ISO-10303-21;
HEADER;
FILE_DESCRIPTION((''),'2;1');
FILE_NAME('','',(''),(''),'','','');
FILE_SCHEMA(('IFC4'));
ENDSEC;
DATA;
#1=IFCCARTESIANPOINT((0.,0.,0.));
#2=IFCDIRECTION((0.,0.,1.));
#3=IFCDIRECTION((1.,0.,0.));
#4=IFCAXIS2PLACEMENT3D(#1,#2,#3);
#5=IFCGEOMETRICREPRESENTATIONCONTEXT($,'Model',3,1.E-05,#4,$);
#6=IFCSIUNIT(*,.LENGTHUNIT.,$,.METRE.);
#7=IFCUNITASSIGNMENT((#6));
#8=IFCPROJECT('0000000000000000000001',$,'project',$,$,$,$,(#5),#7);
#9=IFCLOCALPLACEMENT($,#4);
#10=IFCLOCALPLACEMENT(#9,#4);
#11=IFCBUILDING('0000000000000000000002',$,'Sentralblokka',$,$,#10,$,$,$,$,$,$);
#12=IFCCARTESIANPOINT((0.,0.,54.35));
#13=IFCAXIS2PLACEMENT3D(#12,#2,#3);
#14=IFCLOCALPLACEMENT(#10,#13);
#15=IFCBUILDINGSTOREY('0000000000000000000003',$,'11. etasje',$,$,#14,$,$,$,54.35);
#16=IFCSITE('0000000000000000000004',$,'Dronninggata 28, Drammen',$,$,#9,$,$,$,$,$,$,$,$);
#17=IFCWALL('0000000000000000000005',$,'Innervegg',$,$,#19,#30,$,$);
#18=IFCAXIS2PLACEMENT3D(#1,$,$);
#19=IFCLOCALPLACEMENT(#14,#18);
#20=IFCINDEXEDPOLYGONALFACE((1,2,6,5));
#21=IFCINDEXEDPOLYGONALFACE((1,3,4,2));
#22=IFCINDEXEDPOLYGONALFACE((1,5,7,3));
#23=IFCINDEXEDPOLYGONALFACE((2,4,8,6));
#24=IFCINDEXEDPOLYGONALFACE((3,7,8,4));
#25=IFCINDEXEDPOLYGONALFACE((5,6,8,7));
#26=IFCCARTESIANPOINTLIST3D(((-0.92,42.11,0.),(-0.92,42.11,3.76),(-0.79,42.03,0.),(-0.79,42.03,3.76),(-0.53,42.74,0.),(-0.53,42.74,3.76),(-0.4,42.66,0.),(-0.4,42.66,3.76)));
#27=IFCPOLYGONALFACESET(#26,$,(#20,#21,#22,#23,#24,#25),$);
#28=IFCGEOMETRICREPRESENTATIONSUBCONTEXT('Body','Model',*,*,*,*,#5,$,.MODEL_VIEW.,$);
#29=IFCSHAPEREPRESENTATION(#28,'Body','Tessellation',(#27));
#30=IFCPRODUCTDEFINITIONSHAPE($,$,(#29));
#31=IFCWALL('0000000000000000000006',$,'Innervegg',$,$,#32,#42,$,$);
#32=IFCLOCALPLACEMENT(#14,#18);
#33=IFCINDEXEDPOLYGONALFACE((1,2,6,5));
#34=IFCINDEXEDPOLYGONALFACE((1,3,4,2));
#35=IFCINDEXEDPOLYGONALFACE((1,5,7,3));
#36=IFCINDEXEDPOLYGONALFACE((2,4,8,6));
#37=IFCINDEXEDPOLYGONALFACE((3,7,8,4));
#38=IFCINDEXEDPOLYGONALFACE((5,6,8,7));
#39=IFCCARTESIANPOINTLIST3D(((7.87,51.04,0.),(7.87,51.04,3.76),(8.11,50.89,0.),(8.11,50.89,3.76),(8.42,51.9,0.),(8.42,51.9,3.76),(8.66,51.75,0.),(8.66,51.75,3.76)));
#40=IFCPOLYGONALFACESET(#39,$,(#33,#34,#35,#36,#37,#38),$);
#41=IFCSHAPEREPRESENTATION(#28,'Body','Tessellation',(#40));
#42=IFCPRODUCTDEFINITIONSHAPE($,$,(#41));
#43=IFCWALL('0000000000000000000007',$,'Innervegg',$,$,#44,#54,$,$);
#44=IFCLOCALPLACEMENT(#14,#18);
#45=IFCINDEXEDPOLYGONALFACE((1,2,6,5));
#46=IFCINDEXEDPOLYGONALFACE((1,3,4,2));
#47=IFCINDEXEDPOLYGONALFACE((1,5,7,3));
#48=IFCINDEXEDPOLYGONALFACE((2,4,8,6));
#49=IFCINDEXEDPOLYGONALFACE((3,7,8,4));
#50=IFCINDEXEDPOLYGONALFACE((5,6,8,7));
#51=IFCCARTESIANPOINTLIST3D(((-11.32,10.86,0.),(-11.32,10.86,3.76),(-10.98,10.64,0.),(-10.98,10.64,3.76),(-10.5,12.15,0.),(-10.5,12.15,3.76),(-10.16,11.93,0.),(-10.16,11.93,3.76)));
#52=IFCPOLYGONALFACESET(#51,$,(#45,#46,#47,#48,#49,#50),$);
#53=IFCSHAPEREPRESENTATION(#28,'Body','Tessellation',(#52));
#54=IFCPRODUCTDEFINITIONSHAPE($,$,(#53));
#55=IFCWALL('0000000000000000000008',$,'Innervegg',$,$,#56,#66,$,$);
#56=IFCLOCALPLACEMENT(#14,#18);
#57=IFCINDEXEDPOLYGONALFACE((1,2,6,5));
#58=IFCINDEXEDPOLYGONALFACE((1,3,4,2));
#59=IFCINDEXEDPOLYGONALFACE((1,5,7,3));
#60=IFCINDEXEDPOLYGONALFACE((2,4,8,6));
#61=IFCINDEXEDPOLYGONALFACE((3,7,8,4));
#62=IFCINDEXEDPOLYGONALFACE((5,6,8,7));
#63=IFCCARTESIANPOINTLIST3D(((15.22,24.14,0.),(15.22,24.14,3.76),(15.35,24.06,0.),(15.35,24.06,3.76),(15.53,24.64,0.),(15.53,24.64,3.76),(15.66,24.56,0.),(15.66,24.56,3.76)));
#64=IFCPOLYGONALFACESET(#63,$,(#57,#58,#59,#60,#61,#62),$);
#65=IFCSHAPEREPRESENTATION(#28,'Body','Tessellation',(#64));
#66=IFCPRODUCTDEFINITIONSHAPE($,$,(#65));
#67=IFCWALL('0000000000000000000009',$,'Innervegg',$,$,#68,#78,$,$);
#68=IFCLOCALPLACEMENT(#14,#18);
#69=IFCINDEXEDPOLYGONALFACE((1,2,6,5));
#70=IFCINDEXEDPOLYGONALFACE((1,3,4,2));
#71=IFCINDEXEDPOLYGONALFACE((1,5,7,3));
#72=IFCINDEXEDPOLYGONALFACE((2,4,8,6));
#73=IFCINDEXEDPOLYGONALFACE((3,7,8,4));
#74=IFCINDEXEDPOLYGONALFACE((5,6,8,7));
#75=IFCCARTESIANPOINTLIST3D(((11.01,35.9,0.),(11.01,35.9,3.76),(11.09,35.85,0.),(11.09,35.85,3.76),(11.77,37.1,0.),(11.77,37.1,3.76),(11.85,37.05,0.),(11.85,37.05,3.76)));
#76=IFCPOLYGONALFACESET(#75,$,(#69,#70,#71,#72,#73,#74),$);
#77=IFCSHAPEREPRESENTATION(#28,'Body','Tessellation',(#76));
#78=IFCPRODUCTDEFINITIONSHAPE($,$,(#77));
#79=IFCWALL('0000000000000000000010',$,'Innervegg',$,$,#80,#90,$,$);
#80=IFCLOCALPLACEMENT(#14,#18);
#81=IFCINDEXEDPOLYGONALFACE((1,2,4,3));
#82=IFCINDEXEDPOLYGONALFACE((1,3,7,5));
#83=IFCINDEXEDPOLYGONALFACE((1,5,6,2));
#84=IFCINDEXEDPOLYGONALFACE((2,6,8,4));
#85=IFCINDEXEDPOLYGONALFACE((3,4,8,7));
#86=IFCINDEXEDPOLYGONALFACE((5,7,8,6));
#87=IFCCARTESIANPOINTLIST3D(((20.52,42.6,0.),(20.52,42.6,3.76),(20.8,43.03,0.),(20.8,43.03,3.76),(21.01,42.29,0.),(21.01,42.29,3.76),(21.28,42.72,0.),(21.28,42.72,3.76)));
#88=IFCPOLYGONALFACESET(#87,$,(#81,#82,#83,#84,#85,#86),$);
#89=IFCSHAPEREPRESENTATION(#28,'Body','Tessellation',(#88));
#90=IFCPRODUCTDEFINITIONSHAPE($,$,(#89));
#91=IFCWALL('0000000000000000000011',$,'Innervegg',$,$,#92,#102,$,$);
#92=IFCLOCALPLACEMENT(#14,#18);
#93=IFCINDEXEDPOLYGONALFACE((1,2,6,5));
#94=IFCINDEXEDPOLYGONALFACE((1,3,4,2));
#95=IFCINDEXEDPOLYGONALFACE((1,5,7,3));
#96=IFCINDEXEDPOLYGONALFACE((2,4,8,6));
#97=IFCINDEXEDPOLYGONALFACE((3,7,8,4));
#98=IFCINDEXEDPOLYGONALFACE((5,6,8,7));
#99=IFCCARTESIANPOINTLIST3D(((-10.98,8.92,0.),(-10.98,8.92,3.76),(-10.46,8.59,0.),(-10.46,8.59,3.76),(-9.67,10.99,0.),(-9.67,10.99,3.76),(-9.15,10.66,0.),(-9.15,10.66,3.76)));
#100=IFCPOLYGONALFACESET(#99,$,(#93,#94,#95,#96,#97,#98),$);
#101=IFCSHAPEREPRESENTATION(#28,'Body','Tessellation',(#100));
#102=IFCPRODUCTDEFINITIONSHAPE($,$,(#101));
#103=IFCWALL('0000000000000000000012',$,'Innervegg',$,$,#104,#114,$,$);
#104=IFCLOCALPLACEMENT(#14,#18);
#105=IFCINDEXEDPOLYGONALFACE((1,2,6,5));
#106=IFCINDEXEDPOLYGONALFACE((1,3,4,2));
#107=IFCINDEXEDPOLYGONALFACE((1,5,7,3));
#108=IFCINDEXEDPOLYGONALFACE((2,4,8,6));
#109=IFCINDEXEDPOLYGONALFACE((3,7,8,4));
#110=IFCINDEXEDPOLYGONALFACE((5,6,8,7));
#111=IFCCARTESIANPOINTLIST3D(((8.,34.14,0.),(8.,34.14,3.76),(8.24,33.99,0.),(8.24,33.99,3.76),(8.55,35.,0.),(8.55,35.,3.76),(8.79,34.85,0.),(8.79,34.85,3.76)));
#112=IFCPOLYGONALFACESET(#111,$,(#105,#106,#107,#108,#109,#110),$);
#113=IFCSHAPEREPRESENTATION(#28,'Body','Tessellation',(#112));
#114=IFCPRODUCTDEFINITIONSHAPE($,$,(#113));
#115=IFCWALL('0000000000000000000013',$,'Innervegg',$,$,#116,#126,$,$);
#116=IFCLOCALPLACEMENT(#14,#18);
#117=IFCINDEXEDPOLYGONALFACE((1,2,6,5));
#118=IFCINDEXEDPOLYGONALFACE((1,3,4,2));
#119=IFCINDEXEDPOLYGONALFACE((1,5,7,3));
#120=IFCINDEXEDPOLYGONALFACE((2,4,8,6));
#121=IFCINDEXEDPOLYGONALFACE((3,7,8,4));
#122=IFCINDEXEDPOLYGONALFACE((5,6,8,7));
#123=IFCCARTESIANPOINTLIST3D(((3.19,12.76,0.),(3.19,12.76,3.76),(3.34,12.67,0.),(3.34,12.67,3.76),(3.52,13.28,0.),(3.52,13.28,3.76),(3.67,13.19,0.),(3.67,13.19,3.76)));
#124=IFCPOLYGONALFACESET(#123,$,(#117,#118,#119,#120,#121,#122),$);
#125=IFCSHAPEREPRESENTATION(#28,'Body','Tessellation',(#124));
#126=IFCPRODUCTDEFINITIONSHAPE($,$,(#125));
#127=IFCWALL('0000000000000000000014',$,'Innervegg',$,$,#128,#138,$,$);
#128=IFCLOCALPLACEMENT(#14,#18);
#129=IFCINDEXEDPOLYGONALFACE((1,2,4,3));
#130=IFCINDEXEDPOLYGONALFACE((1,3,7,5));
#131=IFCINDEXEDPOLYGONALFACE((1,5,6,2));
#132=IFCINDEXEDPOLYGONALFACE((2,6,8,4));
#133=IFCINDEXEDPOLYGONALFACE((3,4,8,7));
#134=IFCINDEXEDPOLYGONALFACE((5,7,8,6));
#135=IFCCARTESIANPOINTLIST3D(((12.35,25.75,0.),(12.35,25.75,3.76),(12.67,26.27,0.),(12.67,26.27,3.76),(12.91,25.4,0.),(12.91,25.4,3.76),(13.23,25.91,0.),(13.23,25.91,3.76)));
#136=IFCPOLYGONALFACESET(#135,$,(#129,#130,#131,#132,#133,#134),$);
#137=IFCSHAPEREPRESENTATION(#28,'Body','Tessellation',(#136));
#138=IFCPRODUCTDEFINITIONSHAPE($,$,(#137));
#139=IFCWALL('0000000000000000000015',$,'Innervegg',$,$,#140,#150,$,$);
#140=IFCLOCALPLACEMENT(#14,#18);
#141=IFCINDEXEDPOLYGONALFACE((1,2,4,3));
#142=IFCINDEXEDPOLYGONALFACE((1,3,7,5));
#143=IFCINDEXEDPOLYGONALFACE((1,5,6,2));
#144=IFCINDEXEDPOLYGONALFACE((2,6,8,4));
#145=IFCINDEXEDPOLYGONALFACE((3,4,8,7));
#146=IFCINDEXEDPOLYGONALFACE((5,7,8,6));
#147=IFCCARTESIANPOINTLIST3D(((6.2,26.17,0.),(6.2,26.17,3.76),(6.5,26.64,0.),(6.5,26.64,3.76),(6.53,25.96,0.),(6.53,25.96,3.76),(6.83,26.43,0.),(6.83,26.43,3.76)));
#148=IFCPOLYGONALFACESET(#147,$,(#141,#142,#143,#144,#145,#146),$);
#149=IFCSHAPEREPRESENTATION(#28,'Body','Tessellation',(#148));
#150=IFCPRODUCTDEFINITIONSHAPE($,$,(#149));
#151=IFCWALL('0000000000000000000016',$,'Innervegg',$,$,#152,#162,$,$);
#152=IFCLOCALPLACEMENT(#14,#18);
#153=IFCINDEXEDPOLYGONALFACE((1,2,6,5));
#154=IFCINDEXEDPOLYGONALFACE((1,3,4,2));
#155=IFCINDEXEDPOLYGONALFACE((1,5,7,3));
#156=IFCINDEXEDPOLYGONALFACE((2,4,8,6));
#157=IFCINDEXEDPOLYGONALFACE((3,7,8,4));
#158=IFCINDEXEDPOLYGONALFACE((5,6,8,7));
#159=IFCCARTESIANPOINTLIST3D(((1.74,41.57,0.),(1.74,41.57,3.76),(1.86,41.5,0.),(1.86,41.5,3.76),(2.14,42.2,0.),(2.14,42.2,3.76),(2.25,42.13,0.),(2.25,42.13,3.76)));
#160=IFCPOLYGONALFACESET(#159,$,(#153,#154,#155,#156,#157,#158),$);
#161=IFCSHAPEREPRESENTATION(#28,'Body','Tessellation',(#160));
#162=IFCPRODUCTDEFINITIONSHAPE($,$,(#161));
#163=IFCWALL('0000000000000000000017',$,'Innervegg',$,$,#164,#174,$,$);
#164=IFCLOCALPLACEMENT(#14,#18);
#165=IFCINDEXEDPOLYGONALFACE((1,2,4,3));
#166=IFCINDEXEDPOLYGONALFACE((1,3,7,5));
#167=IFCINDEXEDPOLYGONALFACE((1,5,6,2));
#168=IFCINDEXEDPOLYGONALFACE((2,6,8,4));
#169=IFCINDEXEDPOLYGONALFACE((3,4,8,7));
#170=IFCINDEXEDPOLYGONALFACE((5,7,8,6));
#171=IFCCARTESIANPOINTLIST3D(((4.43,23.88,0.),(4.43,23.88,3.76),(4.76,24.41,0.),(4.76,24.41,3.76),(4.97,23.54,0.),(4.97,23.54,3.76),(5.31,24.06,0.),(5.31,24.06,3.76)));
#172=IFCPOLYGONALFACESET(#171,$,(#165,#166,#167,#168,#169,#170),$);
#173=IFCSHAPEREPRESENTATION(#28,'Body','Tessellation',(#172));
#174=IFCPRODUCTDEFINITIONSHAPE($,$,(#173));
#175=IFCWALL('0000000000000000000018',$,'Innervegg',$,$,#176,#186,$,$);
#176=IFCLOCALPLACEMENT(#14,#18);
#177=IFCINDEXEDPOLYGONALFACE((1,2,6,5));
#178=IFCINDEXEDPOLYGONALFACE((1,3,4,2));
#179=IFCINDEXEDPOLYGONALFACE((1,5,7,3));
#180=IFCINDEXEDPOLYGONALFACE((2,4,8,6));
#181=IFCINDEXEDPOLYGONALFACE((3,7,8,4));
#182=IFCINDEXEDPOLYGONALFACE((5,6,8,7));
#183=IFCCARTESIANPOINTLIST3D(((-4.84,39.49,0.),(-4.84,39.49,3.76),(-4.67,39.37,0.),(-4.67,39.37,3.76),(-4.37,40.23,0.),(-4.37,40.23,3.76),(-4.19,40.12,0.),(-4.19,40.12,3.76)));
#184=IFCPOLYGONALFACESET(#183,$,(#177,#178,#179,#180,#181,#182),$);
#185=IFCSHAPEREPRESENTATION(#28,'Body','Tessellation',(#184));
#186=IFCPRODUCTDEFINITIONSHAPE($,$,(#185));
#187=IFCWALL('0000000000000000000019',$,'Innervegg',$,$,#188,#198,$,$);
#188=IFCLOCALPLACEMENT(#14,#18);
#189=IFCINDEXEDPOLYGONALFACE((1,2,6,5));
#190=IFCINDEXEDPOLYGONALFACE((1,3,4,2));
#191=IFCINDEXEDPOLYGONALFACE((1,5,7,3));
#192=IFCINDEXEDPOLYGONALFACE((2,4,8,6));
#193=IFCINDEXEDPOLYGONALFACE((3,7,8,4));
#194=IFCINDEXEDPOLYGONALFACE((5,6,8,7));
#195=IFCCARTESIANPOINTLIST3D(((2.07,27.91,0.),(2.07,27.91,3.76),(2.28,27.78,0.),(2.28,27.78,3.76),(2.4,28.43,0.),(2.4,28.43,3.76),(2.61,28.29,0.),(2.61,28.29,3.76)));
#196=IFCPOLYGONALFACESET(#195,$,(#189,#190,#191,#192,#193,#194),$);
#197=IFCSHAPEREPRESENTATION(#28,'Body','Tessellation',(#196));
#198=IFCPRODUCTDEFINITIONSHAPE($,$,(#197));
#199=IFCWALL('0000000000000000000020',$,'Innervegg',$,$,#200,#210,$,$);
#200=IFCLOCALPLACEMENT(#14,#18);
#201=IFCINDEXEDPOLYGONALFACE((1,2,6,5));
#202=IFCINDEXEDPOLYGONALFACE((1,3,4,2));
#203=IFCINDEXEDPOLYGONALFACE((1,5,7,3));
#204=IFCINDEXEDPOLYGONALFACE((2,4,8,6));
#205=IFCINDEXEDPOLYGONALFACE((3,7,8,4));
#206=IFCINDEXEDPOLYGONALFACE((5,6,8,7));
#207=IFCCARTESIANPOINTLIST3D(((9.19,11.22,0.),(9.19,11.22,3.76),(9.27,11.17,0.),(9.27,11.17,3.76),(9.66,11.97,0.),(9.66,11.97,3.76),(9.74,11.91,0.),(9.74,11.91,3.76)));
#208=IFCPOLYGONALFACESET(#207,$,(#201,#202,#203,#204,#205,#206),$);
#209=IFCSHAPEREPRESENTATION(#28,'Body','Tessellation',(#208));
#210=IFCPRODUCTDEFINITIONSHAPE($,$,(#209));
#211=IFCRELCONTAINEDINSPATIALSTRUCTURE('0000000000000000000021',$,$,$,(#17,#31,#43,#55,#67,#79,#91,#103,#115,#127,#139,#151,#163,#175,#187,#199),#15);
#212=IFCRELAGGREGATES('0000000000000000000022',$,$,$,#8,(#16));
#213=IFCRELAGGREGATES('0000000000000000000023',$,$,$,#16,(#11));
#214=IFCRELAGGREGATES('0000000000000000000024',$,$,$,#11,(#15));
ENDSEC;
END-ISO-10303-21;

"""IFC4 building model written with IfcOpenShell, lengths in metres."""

from ifc_helpers import new_model, si_unit, frame, origin_with_axes, place, context, subcontext, project, spatial, polyline, outline, extrude, element, save


model = new_model("IFC4")

# Units and contexts
model_context = context("Model", 3, precision=1e-05, world=origin_with_axes())
body_context = subcontext(model_context, "Body", "Model", "MODEL_VIEW")
ifc_project = project(units=[si_unit("LENGTHUNIT", "METRE")], contexts=[model_context])

# Site, building, storey
site_placement = place(None, origin_with_axes())
site = spatial("IfcSite", under=ifc_project, at=site_placement, Name="Dronninggata 28, Drammen")
building_placement = place(site_placement, origin_with_axes())
building = spatial("IfcBuilding", under=site, at=building_placement, Name="Sentralblokka")
storey_placement = place(building_placement, frame((0.0, 0.0, 54.35), z_axis=(0.0, 0.0, 1.0), x_axis=(1.0, 0.0, 0.0)))
storey = spatial("IfcBuildingStorey", under=building, at=storey_placement, Name="11. etasje", Elevation=54.35)

# Walls
wall_1_placement = place(storey_placement, frame((0.0, 0.0, -54.35), z_axis=(0.0, 0.0, 1.0), x_axis=(1.0, 0.0, 0.0)))
element("IfcWall", 1, at=wall_1_placement, inside=storey, Name="Innervegg", context=body_context, shape_type="SweptSolid", body=[
    extrude(outline(polyline([(-0.4, 42.66), (-0.79, 42.03), (-0.92, 42.11), (-0.53, 42.74), (-0.4, 42.66)])), frame((0.0, 0.0, 54.35)), (0.0, 0.0, 1.0), 3.76),
])
wall_2_placement = place(storey_placement, frame((0.0, 0.0, -54.35), z_axis=(0.0, 0.0, 1.0), x_axis=(1.0, 0.0, 0.0)))
element("IfcWall", 2, at=wall_2_placement, inside=storey, Name="Innervegg", context=body_context, shape_type="SweptSolid", body=[
    extrude(outline(polyline([(8.66, 51.75), (8.11, 50.89), (7.87, 51.04), (8.42, 51.9), (8.66, 51.75)])), frame((0.0, 0.0, 54.35)), (0.0, 0.0, 1.0), 3.76),
])
wall_3_placement = place(storey_placement, frame((0.0, 0.0, -54.35), z_axis=(0.0, 0.0, 1.0), x_axis=(1.0, 0.0, 0.0)))
element("IfcWall", 3, at=wall_3_placement, inside=storey, Name="Innervegg", context=body_context, shape_type="SweptSolid", body=[
    extrude(outline(polyline([(-10.16, 11.93), (-10.98, 10.64), (-11.32, 10.86), (-10.5, 12.15), (-10.16, 11.93)])), frame((0.0, 0.0, 54.35)), (0.0, 0.0, 1.0), 3.76),
])
wall_4_placement = place(storey_placement, frame((0.0, 0.0, -54.35), z_axis=(0.0, 0.0, 1.0), x_axis=(1.0, 0.0, 0.0)))
element("IfcWall", 4, at=wall_4_placement, inside=storey, Name="Innervegg", context=body_context, shape_type="SweptSolid", body=[
    extrude(outline(polyline([(15.66, 24.56), (15.35, 24.06), (15.22, 24.14), (15.53, 24.64), (15.66, 24.56)])), frame((0.0, 0.0, 54.35)), (0.0, 0.0, 1.0), 3.76),
])
wall_5_placement = place(storey_placement, frame((0.0, 0.0, -54.35), z_axis=(0.0, 0.0, 1.0), x_axis=(1.0, 0.0, 0.0)))
element("IfcWall", 5, at=wall_5_placement, inside=storey, Name="Innervegg", context=body_context, shape_type="SweptSolid", body=[
    extrude(outline(polyline([(11.85, 37.05), (11.09, 35.85), (11.01, 35.9), (11.77, 37.1), (11.85, 37.05)])), frame((0.0, 0.0, 54.35)), (0.0, 0.0, 1.0), 3.76),
])
wall_6_placement = place(storey_placement, frame((0.0, 0.0, -54.35), z_axis=(0.0, 0.0, 1.0), x_axis=(1.0, 0.0, 0.0)))
element("IfcWall", 6, at=wall_6_placement, inside=storey, Name="Innervegg", context=body_context, shape_type="SweptSolid", body=[
    extrude(outline(polyline([(21.28, 42.72), (21.01, 42.29), (20.52, 42.6), (20.8, 43.03), (21.28, 42.72)])), frame((0.0, 0.0, 54.35)), (0.0, 0.0, 1.0), 3.76),
])
wall_7_placement = place(storey_placement, frame((0.0, 0.0, -54.35), z_axis=(0.0, 0.0, 1.0), x_axis=(1.0, 0.0, 0.0)))
element("IfcWall", 7, at=wall_7_placement, inside=storey, Name="Innervegg", context=body_context, shape_type="SweptSolid", body=[
    extrude(outline(polyline([(-9.15, 10.66), (-10.46, 8.59), (-10.98, 8.92), (-9.67, 10.99), (-9.15, 10.66)])), frame((0.0, 0.0, 54.35)), (0.0, 0.0, 1.0), 3.76),
])
wall_8_placement = place(storey_placement, frame((0.0, 0.0, -54.35), z_axis=(0.0, 0.0, 1.0), x_axis=(1.0, 0.0, 0.0)))
element("IfcWall", 8, at=wall_8_placement, inside=storey, Name="Innervegg", context=body_context, shape_type="SweptSolid", body=[
    extrude(outline(polyline([(8.79, 34.85), (8.24, 33.99), (8.0, 34.14), (8.55, 35.0), (8.79, 34.85)])), frame((0.0, 0.0, 54.35)), (0.0, 0.0, 1.0), 3.76),
])
wall_9_placement = place(storey_placement, frame((0.0, 0.0, -54.35), z_axis=(0.0, 0.0, 1.0), x_axis=(1.0, 0.0, 0.0)))
element("IfcWall", 9, at=wall_9_placement, inside=storey, Name="Innervegg", context=body_context, shape_type="SweptSolid", body=[
    extrude(outline(polyline([(3.67, 13.19), (3.34, 12.67), (3.19, 12.76), (3.52, 13.28), (3.67, 13.19)])), frame((0.0, 0.0, 54.35)), (0.0, 0.0, 1.0), 3.76),
])
wall_10_placement = place(storey_placement, frame((0.0, 0.0, -54.35), z_axis=(0.0, 0.0, 1.0), x_axis=(1.0, 0.0, 0.0)))
element("IfcWall", 10, at=wall_10_placement, inside=storey, Name="Innervegg", context=body_context, shape_type="SweptSolid", body=[
    extrude(outline(polyline([(13.23, 25.91), (12.91, 25.4), (12.35, 25.75), (12.67, 26.27), (13.23, 25.91)])), frame((0.0, 0.0, 54.35)), (0.0, 0.0, 1.0), 3.76),
])
wall_11_placement = place(storey_placement, frame((0.0, 0.0, -54.35), z_axis=(0.0, 0.0, 1.0), x_axis=(1.0, 0.0, 0.0)))
element("IfcWall", 11, at=wall_11_placement, inside=storey, Name="Innervegg", context=body_context, shape_type="SweptSolid", body=[
    extrude(outline(polyline([(6.83, 26.43), (6.53, 25.96), (6.2, 26.17), (6.5, 26.64), (6.83, 26.43)])), frame((0.0, 0.0, 54.35)), (0.0, 0.0, 1.0), 3.76),
])
wall_12_placement = place(storey_placement, frame((0.0, 0.0, -54.35), z_axis=(0.0, 0.0, 1.0), x_axis=(1.0, 0.0, 0.0)))
element("IfcWall", 12, at=wall_12_placement, inside=storey, Name="Innervegg", context=body_context, shape_type="SweptSolid", body=[
    extrude(outline(polyline([(2.25, 42.13), (1.86, 41.5), (1.74, 41.57), (2.14, 42.2), (2.25, 42.13)])), frame((0.0, 0.0, 54.35)), (0.0, 0.0, 1.0), 3.76),
])
wall_13_placement = place(storey_placement, frame((0.0, 0.0, -54.35), z_axis=(0.0, 0.0, 1.0), x_axis=(1.0, 0.0, 0.0)))
element("IfcWall", 13, at=wall_13_placement, inside=storey, Name="Innervegg", context=body_context, shape_type="SweptSolid", body=[
    extrude(outline(polyline([(5.31, 24.06), (4.97, 23.54), (4.43, 23.88), (4.76, 24.41), (5.31, 24.06)])), frame((0.0, 0.0, 54.35)), (0.0, 0.0, 1.0), 3.76),
])
wall_14_placement = place(storey_placement, frame((0.0, 0.0, -54.35), z_axis=(0.0, 0.0, 1.0), x_axis=(1.0, 0.0, 0.0)))
element("IfcWall", 14, at=wall_14_placement, inside=storey, Name="Innervegg", context=body_context, shape_type="SweptSolid", body=[
    extrude(outline(polyline([(-4.19, 40.12), (-4.67, 39.37), (-4.84, 39.49), (-4.37, 40.23), (-4.19, 40.12)])), frame((0.0, 0.0, 54.35)), (0.0, 0.0, 1.0), 3.76),
])
wall_15_placement = place(storey_placement, frame((0.0, 0.0, -54.35), z_axis=(0.0, 0.0, 1.0), x_axis=(1.0, 0.0, 0.0)))
element("IfcWall", 15, at=wall_15_placement, inside=storey, Name="Innervegg", context=body_context, shape_type="SweptSolid", body=[
    extrude(outline(polyline([(2.61, 28.29), (2.28, 27.78), (2.07, 27.91), (2.4, 28.43), (2.61, 28.29)])), frame((0.0, 0.0, 54.35)), (0.0, 0.0, 1.0), 3.76),
])
wall_16_placement = place(storey_placement, frame((0.0, 0.0, -54.35), z_axis=(0.0, 0.0, 1.0), x_axis=(1.0, 0.0, 0.0)))
element("IfcWall", 16, at=wall_16_placement, inside=storey, Name="Innervegg", context=body_context, shape_type="SweptSolid", body=[
    extrude(outline(polyline([(9.74, 11.91), (9.27, 11.17), (9.19, 11.22), (9.66, 11.97), (9.74, 11.91)])), frame((0.0, 0.0, 54.35)), (0.0, 0.0, 1.0), 3.76),
])

save(model, "model.ifc")
